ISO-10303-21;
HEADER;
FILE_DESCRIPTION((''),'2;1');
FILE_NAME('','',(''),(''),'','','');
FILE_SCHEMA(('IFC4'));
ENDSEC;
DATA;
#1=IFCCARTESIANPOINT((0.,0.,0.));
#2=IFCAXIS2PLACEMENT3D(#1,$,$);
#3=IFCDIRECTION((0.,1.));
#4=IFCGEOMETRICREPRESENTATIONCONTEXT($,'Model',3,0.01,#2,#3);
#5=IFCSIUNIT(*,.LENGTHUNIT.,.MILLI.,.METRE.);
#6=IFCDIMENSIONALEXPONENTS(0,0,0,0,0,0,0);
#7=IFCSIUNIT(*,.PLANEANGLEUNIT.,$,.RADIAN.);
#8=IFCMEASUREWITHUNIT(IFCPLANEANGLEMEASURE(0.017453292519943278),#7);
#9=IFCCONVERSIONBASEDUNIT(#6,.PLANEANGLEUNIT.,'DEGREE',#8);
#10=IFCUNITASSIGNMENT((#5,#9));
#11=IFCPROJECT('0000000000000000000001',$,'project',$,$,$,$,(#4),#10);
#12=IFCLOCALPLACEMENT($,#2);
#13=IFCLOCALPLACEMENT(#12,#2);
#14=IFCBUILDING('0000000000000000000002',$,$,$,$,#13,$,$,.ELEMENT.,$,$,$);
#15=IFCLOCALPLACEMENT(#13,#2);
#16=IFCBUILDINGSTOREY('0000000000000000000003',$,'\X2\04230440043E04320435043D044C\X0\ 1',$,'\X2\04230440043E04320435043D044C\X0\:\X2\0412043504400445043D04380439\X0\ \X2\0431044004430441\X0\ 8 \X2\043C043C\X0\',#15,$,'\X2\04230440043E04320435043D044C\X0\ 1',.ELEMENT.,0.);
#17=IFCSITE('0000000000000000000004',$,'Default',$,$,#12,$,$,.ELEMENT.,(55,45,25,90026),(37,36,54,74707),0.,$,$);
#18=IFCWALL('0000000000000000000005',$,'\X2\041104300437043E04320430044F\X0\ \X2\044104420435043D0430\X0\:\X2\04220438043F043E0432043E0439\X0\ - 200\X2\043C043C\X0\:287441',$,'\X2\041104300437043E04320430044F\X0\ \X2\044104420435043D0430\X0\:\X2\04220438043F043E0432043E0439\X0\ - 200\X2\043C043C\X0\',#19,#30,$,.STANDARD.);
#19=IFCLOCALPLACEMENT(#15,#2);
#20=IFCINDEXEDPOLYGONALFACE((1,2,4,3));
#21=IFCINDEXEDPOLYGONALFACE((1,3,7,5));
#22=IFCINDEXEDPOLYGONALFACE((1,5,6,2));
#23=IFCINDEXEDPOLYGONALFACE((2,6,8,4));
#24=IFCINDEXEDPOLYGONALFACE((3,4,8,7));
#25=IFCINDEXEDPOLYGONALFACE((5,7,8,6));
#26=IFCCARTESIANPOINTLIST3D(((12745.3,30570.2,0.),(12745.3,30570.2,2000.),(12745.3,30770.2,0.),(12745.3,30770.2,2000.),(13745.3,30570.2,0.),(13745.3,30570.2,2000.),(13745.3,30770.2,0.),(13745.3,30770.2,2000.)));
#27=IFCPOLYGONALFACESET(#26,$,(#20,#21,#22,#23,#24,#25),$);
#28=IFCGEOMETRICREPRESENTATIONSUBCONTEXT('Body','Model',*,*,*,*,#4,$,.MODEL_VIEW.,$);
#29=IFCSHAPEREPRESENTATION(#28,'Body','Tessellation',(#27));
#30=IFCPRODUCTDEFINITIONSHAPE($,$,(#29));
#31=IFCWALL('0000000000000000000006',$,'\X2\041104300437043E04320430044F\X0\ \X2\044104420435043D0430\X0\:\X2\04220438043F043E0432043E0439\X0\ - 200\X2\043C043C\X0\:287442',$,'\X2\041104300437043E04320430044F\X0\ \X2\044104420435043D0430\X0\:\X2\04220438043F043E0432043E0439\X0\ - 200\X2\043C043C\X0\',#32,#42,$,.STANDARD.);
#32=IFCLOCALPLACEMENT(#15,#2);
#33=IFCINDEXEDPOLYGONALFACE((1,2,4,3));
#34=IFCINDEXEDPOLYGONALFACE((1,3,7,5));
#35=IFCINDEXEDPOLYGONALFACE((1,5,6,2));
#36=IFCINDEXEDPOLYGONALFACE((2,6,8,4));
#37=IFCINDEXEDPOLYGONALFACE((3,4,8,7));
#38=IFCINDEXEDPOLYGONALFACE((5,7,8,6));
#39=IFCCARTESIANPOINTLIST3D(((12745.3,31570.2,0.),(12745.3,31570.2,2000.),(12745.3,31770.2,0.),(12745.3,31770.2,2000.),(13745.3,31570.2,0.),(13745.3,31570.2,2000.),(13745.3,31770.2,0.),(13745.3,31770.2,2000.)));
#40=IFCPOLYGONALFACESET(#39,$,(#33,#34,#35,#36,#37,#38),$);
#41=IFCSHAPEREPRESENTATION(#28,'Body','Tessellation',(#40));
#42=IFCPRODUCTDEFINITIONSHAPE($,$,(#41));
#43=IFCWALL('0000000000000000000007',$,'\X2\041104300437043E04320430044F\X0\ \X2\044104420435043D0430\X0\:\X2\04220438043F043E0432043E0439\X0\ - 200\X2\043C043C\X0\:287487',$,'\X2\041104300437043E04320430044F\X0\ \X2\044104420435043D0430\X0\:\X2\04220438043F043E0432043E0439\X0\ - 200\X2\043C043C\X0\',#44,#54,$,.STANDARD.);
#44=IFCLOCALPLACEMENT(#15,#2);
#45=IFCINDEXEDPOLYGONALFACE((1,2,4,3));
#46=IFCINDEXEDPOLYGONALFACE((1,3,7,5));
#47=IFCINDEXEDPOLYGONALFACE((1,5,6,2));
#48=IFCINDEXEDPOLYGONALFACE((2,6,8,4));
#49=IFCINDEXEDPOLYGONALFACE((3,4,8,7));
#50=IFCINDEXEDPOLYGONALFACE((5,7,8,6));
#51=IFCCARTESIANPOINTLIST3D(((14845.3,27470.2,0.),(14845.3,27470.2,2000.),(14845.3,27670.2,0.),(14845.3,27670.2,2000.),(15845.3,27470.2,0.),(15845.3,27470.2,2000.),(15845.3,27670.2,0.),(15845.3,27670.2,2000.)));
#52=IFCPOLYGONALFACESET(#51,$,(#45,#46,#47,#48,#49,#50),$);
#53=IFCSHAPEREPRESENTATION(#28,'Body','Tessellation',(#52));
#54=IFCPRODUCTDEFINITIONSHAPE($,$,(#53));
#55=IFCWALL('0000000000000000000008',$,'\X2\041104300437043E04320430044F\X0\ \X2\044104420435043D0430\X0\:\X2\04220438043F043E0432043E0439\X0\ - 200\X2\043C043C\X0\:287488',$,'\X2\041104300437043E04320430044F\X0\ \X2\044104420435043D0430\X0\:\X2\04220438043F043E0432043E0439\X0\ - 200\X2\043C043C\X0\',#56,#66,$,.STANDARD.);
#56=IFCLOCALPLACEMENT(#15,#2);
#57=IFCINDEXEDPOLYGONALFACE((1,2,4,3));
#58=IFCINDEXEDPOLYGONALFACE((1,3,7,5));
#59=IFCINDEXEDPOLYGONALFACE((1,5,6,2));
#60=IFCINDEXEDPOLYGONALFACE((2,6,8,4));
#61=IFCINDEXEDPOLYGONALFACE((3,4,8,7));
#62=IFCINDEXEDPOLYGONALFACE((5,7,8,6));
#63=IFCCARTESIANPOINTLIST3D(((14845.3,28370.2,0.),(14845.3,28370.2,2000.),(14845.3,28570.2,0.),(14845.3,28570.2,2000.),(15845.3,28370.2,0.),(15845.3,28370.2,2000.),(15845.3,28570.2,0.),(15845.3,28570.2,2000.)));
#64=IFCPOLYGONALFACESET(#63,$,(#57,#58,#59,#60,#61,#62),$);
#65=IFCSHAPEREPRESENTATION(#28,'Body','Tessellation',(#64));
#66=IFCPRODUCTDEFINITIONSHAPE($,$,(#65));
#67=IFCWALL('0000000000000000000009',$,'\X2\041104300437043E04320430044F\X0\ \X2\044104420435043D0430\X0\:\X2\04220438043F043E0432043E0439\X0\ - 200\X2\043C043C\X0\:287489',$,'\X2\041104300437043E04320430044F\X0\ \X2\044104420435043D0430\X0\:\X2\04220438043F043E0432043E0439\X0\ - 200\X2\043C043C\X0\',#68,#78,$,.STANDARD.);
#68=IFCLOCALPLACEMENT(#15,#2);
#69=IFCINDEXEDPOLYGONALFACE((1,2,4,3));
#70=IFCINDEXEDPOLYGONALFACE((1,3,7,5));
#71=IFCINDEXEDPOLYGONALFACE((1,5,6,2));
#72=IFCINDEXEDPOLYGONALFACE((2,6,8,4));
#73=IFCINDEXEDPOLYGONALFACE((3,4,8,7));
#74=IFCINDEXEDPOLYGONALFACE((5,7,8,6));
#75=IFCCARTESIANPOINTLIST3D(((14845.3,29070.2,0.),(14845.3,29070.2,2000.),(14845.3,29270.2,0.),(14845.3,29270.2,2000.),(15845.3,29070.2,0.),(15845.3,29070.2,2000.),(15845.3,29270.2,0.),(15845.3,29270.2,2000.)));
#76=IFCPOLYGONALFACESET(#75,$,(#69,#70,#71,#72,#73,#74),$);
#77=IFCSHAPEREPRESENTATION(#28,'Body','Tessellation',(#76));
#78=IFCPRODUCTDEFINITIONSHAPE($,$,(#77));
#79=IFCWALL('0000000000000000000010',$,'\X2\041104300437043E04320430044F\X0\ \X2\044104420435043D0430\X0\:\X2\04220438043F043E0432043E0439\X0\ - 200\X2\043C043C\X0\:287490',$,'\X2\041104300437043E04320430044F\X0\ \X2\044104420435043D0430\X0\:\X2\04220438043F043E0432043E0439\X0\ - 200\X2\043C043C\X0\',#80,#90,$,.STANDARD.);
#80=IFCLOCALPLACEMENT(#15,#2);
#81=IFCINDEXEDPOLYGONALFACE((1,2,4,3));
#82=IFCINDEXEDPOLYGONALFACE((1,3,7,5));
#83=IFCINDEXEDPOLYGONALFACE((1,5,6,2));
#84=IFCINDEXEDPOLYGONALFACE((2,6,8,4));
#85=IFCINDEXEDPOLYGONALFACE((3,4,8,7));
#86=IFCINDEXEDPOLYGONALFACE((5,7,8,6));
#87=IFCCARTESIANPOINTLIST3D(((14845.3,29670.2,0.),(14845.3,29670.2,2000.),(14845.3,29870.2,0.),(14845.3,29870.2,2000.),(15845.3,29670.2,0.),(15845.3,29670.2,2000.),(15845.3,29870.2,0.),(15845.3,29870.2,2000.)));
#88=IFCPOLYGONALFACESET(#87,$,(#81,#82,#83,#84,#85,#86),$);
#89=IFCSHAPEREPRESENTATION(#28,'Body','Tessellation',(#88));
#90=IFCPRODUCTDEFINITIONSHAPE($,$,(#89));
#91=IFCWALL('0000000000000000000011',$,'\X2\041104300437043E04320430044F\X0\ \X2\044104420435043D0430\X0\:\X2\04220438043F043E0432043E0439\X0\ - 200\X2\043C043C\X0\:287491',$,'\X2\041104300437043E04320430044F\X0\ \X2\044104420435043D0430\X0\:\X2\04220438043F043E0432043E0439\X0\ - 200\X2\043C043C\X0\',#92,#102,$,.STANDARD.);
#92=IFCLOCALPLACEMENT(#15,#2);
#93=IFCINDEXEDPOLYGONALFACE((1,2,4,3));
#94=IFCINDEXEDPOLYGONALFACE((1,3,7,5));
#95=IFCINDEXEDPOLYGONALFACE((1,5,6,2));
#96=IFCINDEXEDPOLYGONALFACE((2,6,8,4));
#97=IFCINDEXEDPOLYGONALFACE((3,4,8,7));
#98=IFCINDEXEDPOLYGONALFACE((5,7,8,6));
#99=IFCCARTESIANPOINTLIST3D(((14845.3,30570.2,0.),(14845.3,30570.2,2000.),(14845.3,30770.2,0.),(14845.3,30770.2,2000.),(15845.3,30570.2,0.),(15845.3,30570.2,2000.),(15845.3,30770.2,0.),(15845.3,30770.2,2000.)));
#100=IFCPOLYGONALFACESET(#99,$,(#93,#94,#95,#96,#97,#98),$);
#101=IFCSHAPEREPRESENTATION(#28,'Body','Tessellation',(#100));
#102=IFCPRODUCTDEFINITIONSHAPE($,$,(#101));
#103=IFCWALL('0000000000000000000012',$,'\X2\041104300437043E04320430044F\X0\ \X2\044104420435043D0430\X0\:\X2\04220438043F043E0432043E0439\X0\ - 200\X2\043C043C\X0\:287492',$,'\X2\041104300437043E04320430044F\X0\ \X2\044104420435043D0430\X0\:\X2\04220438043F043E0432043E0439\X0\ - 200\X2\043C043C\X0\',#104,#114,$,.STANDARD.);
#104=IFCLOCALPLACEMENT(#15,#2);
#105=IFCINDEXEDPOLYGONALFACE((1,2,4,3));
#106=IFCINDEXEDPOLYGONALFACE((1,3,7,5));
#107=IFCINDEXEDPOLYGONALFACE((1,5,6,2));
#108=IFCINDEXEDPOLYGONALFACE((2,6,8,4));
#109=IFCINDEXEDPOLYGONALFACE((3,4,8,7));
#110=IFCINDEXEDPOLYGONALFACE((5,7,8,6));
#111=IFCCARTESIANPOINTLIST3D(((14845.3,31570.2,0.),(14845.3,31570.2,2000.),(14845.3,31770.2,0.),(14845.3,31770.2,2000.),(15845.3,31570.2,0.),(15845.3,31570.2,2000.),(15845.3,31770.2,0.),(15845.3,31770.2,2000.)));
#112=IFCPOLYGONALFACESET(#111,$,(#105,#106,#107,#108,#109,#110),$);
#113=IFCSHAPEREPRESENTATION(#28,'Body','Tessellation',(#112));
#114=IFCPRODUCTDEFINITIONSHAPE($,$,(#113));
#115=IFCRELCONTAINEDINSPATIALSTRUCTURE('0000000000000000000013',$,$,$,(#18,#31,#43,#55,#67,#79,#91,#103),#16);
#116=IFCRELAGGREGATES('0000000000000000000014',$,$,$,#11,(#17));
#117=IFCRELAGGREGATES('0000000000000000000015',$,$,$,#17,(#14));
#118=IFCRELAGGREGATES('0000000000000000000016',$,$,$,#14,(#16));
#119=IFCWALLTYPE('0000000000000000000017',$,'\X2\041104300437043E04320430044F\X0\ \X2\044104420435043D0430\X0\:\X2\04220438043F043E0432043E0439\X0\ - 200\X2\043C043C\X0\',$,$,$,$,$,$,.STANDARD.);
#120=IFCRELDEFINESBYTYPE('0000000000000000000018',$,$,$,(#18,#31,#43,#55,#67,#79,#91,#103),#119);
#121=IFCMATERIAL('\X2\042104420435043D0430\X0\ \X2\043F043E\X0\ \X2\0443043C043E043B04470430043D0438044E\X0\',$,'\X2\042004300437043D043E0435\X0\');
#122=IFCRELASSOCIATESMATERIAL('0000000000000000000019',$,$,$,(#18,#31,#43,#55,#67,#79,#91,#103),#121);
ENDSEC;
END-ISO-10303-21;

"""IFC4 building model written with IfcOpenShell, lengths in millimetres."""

from ifc_helpers import new_model, entity, si_unit, converted_unit, direction, frame, origin, place, context, subcontext, project, spatial, indexed_curve, outline, extrude, material, type_object, element, save


model = new_model("IFC4")

# Units and contexts
model_context = context("Model", 3, precision=0.01, world=origin(), true_north=direction((0.0, 1.0)))
body_context = subcontext(model_context, "Body", "Model", "MODEL_VIEW")
ifc_project = project(units=[si_unit("LENGTHUNIT", "METRE", prefix="MILLI"), converted_unit("PLANEANGLEUNIT", "DEGREE", entity("IfcPlaneAngleMeasure", 0.017453292519943278), si_unit("PLANEANGLEUNIT", "RADIAN"), dimensions=[0, 0, 0, 0, 0, 0, 0])], contexts=[model_context])

# Site, building, storey
site_placement = place(None, origin())
site = spatial("IfcSite", under=ifc_project, at=site_placement, Name="Default", CompositionType="ELEMENT", RefLatitude=(55, 45, 25, 90026), RefLongitude=(37, 36, 54, 74707), RefElevation=0.0)
building_placement = place(site_placement, origin())
building = spatial("IfcBuilding", under=site, at=building_placement, CompositionType="ELEMENT")
storey_placement = place(building_placement, origin())
storey = spatial("IfcBuildingStorey", under=building, at=storey_placement, Name="Уровень 1", ObjectType="Уровень:Верхний брус 8 мм", LongName="Уровень 1", CompositionType="ELEMENT", Elevation=0.0)

# Walls
ifc_material = material(Name="Стена по умолчанию", Category="Разное")
wall_type = type_object("IfcWallType", Name="Базовая стена:Типовой - 200мм", PredefinedType="STANDARD")
for number, where, name in (
    (1, (12745.3, 30670.2, 0.0), "Базовая стена:Типовой - 200мм:287441"),
    (2, (12745.3, 31670.2, 0.0), "Базовая стена:Типовой - 200мм:287442"),
):
    element("IfcWall", number, at=place(storey_placement, frame(where)), inside=storey, type_object=wall_type, material=ifc_material, Name=name, ObjectType="Базовая стена:Типовой - 200мм", PredefinedType="STANDARD", context=body_context, shape_type="SweptSolid", body=[
        extrude(outline(indexed_curve([(1000.0, 100.0), (0.0, 100.0), (0.0, -100.0), (1000.0, -100.0), (1000.0, 100.0)], self_intersect=False)), origin(), (0.0, 0.0, 1.0), 2000.0),
    ])
wall_1_placement = place(storey_placement, frame((14845.3, 27570.2, 0.0)))
element("IfcWall", 3, at=wall_1_placement, inside=storey, type_object=wall_type, material=ifc_material, Name="Базовая стена:Типовой - 200мм:287487", ObjectType="Базовая стена:Типовой - 200мм", PredefinedType="STANDARD", context=body_context, shape_type="SweptSolid", body=[
    extrude(outline(indexed_curve([(1000.0, 100.0), (0.0, 100.0), (0.0, -100.0), (1000.0, -100.0), (1000.0, 100.0)], self_intersect=False)), origin(), (0.0, 0.0, 1.0), 2000.0),
])
wall_2_placement = place(storey_placement, frame((14845.3, 28470.2, 0.0)))
element("IfcWall", 4, at=wall_2_placement, inside=storey, type_object=wall_type, material=ifc_material, Name="Базовая стена:Типовой - 200мм:287488", ObjectType="Базовая стена:Типовой - 200мм", PredefinedType="STANDARD", context=body_context, shape_type="SweptSolid", body=[
    extrude(outline(indexed_curve([(1000.0, 100.0), (0.0, 100.0), (0.0, -100.0), (1000.0, -100.0), (1000.0, 100.0)], self_intersect=False)), origin(), (0.0, 0.0, 1.0), 2000.0),
])
wall_3_placement = place(storey_placement, frame((14845.3, 29170.2, 0.0)))
element("IfcWall", 5, at=wall_3_placement, inside=storey, type_object=wall_type, material=ifc_material, Name="Базовая стена:Типовой - 200мм:287489", ObjectType="Базовая стена:Типовой - 200мм", PredefinedType="STANDARD", context=body_context, shape_type="SweptSolid", body=[
    extrude(outline(indexed_curve([(1000.0, 100.0), (0.0, 100.0), (0.0, -100.0), (1000.0, -100.0), (1000.0, 100.0)], self_intersect=False)), origin(), (0.0, 0.0, 1.0), 2000.0),
])
wall_4_placement = place(storey_placement, frame((14845.3, 29770.2, 0.0)))
element("IfcWall", 6, at=wall_4_placement, inside=storey, type_object=wall_type, material=ifc_material, Name="Базовая стена:Типовой - 200мм:287490", ObjectType="Базовая стена:Типовой - 200мм", PredefinedType="STANDARD", context=body_context, shape_type="SweptSolid", body=[
    extrude(outline(indexed_curve([(1000.0, 100.0), (0.0, 100.0), (0.0, -100.0), (1000.0, -100.0), (1000.0, 100.0)], self_intersect=False)), origin(), (0.0, 0.0, 1.0), 2000.0),
])
wall_5_placement = place(storey_placement, frame((14845.3, 30670.2, 0.0)))
element("IfcWall", 7, at=wall_5_placement, inside=storey, type_object=wall_type, material=ifc_material, Name="Базовая стена:Типовой - 200мм:287491", ObjectType="Базовая стена:Типовой - 200мм", PredefinedType="STANDARD", context=body_context, shape_type="SweptSolid", body=[
    extrude(outline(indexed_curve([(1000.0, 100.0), (0.0, 100.0), (0.0, -100.0), (1000.0, -100.0), (1000.0, 100.0)], self_intersect=False)), origin(), (0.0, 0.0, 1.0), 2000.0),
])
wall_6_placement = place(storey_placement, frame((14845.3, 31670.2, 0.0)))
element("IfcWall", 8, at=wall_6_placement, inside=storey, type_object=wall_type, material=ifc_material, Name="Базовая стена:Типовой - 200мм:287492", ObjectType="Базовая стена:Типовой - 200мм", PredefinedType="STANDARD", context=body_context, shape_type="SweptSolid", body=[
    extrude(outline(indexed_curve([(1000.0, 100.0), (0.0, 100.0), (0.0, -100.0), (1000.0, -100.0), (1000.0, 100.0)], self_intersect=False)), origin(), (0.0, 0.0, 1.0), 2000.0),
])

save(model, "model.ifc")
